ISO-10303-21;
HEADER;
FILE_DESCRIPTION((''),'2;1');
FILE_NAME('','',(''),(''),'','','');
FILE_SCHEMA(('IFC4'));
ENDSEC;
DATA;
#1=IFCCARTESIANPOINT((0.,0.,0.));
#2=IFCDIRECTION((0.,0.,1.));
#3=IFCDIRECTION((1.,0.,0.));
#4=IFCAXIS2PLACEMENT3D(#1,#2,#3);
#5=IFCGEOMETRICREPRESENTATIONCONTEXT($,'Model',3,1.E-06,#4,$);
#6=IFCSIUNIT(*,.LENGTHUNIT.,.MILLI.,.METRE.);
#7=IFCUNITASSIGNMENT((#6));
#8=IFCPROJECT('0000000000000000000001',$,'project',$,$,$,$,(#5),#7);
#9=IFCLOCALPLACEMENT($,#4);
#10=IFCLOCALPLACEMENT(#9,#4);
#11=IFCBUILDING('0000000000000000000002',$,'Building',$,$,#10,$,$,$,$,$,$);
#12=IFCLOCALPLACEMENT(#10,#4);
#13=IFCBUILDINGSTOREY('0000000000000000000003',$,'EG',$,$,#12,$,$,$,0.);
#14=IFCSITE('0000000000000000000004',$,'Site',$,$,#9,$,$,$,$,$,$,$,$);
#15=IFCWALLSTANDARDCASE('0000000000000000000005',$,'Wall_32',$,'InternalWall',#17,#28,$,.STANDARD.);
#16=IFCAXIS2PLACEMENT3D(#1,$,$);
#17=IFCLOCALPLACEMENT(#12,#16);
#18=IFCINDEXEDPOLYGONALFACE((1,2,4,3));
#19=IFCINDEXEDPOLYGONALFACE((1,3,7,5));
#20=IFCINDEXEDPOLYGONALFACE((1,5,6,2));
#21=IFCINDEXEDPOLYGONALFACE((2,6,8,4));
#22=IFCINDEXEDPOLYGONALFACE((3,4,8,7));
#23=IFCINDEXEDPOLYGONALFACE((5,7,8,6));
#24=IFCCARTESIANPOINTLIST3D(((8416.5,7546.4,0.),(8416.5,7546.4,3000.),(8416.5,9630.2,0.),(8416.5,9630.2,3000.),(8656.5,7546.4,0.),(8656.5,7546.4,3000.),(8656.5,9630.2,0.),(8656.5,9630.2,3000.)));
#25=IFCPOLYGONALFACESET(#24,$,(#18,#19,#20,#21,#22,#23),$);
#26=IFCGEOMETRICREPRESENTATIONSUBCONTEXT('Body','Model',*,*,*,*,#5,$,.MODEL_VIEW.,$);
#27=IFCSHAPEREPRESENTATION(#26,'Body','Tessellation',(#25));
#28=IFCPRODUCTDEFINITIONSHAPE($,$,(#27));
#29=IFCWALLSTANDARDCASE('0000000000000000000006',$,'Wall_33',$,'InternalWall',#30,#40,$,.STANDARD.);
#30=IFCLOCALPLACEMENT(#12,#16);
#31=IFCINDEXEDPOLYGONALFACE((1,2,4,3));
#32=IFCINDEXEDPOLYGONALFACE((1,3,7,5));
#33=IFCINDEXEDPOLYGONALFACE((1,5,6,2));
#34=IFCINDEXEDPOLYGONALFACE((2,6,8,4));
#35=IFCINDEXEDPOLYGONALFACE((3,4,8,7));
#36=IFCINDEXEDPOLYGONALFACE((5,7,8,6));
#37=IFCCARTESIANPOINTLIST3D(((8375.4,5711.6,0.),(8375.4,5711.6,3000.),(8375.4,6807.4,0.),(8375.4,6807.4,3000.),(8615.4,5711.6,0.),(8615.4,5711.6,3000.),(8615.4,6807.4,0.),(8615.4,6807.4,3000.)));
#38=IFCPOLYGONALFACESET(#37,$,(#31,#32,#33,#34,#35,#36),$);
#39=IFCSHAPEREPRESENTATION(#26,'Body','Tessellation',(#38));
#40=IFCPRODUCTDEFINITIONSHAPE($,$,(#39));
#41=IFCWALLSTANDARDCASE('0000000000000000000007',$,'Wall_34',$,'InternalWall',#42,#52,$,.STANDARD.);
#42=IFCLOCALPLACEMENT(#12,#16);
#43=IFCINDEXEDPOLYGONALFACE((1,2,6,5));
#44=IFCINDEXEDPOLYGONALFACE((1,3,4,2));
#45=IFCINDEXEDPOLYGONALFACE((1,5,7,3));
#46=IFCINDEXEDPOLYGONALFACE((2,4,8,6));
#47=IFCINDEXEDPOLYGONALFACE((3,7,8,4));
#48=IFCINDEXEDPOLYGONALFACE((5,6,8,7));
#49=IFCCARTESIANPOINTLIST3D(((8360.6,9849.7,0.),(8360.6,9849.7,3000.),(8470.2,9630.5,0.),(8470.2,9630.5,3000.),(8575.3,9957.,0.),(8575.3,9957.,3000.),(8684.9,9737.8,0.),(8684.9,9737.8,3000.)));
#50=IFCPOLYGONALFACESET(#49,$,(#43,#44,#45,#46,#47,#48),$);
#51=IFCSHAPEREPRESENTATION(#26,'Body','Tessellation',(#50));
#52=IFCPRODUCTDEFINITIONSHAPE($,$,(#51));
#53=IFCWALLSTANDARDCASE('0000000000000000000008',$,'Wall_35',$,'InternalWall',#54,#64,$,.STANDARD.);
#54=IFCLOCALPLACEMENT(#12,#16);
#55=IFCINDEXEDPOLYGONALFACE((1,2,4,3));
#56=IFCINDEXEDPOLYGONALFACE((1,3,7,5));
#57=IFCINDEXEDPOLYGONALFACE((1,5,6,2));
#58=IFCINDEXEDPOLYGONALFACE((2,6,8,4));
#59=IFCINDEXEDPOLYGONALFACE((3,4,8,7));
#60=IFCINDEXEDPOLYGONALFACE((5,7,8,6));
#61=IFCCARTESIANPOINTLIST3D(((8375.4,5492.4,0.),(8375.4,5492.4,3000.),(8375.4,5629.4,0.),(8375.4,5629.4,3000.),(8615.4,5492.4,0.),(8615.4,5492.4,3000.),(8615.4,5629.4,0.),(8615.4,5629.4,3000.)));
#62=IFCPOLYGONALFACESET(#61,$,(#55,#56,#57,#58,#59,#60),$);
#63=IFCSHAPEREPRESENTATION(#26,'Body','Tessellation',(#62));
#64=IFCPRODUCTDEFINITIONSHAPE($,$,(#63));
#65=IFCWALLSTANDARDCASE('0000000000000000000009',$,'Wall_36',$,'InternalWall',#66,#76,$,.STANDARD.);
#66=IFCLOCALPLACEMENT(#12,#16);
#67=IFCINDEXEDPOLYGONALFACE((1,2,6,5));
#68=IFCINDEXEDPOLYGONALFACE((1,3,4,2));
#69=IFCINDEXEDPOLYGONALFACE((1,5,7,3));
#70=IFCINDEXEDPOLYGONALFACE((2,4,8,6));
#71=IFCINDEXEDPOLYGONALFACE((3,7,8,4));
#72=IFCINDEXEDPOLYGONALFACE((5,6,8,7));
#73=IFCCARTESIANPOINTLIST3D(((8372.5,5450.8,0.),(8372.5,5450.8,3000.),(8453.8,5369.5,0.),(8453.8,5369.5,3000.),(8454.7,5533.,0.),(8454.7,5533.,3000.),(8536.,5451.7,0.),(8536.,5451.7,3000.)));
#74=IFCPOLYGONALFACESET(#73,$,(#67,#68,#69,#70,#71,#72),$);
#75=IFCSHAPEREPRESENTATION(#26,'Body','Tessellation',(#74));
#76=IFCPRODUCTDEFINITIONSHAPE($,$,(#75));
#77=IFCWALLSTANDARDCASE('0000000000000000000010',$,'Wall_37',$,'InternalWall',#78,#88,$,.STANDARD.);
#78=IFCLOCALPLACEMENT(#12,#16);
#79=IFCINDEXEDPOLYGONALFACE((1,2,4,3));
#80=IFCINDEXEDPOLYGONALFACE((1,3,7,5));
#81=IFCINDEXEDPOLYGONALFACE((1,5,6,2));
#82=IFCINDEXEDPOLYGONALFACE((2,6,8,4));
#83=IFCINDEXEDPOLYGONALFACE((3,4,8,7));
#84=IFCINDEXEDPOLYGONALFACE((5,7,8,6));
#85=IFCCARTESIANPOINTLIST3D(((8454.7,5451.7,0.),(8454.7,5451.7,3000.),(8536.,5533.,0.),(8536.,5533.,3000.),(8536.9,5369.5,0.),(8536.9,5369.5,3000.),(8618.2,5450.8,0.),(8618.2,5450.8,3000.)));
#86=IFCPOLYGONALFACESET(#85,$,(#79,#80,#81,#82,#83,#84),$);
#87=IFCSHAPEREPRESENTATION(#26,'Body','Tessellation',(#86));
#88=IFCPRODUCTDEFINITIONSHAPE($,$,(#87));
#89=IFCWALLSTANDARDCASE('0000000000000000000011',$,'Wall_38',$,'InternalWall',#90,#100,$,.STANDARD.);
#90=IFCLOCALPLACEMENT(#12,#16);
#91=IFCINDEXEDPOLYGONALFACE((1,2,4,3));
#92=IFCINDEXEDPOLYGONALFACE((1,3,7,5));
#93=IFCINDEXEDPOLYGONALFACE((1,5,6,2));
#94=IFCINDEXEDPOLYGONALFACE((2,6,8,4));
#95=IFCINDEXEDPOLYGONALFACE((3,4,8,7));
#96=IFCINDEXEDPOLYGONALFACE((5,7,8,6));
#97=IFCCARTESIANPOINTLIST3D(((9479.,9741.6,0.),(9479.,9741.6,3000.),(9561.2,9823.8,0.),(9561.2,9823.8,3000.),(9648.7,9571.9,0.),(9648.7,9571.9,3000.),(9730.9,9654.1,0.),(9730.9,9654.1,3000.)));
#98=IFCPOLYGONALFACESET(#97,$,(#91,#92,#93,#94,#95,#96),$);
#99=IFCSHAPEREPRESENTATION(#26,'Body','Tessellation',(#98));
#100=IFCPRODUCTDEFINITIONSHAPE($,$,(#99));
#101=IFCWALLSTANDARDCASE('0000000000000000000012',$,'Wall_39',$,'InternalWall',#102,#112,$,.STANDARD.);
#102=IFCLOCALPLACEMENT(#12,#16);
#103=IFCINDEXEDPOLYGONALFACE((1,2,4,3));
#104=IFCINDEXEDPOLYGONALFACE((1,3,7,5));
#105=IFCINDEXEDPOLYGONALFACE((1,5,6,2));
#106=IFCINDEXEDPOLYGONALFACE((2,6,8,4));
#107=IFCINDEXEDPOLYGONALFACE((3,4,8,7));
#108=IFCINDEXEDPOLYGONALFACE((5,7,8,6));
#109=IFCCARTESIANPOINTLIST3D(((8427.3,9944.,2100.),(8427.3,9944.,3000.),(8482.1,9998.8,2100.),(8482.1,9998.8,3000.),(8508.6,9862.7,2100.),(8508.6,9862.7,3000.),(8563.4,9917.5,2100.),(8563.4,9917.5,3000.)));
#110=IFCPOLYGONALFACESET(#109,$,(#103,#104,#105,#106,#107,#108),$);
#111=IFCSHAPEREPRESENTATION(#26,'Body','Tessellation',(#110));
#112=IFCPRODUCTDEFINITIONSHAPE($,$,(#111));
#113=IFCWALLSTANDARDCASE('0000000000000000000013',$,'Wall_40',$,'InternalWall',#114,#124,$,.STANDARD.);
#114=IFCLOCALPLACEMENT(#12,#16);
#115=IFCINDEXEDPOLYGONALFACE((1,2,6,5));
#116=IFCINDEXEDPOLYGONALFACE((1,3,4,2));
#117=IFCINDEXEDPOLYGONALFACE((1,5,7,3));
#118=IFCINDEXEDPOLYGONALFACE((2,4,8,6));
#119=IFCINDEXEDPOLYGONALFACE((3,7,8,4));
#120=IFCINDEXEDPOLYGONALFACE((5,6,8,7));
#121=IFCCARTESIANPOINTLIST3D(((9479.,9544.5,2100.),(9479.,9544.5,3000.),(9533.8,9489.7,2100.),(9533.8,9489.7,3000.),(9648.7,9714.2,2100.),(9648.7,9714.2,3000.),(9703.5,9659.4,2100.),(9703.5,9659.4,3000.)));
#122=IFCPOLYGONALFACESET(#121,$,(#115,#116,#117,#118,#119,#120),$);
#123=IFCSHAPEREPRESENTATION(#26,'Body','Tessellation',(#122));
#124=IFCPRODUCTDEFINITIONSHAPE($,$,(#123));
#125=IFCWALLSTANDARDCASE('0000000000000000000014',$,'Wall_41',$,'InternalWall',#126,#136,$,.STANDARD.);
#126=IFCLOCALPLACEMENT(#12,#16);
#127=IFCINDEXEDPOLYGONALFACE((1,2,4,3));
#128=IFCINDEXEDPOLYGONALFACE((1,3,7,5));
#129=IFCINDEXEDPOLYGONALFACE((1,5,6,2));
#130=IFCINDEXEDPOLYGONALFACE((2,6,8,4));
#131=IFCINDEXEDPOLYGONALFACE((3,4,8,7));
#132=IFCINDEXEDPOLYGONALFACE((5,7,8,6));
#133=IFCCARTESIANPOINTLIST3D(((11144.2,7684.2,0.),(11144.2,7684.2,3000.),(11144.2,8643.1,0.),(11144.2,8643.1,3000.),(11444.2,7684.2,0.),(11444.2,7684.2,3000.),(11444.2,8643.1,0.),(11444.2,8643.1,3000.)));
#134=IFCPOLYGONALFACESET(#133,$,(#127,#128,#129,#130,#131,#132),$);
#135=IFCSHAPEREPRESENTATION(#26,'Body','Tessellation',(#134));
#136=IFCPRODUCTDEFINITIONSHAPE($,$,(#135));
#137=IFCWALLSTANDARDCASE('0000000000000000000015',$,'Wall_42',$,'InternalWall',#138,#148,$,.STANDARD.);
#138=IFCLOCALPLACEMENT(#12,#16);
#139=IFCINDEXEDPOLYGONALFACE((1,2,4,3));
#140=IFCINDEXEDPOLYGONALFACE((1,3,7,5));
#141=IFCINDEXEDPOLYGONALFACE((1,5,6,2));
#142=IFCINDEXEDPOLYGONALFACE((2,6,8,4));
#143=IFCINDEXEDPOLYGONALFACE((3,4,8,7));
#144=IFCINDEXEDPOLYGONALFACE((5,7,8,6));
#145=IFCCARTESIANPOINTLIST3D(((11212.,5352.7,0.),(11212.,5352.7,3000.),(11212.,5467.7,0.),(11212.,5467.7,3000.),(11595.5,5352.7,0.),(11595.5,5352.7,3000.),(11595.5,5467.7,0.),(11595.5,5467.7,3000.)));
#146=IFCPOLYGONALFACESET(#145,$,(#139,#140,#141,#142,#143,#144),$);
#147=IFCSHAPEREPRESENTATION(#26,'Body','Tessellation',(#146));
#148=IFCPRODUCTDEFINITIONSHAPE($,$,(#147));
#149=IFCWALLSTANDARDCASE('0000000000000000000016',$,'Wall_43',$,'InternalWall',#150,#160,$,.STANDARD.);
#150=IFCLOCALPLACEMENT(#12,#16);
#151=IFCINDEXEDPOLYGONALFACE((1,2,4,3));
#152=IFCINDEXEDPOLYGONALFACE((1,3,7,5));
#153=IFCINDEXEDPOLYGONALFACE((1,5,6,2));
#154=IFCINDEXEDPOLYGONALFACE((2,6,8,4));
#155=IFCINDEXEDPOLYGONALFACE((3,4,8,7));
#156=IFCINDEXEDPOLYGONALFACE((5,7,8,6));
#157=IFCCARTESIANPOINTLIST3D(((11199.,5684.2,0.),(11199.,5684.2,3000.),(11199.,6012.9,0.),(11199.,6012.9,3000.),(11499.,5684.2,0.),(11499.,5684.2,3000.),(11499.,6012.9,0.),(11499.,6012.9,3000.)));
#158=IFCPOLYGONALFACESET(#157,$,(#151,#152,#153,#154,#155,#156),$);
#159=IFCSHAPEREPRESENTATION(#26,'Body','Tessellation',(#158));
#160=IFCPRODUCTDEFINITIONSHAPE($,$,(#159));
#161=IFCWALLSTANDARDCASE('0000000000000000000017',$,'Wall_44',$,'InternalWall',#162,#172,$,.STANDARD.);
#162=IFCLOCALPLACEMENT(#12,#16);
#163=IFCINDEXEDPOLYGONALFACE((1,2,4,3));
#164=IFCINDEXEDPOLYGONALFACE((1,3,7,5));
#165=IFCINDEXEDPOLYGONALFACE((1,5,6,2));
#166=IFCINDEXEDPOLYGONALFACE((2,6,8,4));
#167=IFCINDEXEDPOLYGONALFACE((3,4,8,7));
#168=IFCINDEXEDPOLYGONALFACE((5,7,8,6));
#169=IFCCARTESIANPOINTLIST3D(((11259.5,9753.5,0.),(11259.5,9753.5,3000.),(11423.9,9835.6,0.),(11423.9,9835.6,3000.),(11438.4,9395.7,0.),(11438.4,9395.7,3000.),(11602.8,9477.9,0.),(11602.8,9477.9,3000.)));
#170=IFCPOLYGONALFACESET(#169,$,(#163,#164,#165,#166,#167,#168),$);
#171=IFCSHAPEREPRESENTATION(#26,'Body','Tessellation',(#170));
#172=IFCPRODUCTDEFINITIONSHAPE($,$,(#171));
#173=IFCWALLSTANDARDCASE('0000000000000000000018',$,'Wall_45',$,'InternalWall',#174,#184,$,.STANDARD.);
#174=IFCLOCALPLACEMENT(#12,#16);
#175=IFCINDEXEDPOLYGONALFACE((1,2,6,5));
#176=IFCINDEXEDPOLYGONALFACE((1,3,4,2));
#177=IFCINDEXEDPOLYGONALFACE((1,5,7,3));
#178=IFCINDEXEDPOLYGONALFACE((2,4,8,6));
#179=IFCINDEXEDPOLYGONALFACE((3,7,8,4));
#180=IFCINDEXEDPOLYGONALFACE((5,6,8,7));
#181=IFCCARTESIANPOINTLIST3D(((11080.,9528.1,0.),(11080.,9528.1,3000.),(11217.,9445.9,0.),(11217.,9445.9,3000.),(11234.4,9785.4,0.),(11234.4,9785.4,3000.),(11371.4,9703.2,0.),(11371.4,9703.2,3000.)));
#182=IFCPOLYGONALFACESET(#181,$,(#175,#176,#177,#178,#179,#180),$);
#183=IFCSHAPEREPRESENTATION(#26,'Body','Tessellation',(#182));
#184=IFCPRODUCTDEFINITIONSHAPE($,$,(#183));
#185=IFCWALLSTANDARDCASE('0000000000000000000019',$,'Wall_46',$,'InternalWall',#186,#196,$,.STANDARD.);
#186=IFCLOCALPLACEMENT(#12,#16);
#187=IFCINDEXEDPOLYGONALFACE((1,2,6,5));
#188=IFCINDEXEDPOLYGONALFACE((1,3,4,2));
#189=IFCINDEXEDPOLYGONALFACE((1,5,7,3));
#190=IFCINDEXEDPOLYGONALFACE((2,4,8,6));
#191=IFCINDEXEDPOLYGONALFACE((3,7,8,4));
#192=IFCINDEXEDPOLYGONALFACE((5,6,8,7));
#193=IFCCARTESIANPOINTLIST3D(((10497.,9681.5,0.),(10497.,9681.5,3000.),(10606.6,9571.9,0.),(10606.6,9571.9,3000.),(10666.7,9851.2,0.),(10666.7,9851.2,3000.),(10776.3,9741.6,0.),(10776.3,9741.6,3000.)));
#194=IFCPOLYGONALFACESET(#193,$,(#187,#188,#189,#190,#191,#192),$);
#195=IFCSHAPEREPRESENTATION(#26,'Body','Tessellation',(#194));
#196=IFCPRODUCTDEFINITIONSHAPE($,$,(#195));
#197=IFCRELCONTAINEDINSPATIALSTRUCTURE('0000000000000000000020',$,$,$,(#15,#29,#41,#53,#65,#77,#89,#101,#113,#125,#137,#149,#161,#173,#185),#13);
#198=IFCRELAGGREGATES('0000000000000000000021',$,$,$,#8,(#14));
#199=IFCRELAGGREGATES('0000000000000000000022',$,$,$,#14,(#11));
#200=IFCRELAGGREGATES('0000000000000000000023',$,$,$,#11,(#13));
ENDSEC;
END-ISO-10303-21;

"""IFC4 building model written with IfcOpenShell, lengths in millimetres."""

from ifc_helpers import new_model, si_unit, frame, origin_with_axes, place, context, subcontext, project, spatial, rectangle, extrude, element, save


model = new_model("IFC4")

# Units and contexts
model_context = context("Model", 3, precision=1e-06, world=origin_with_axes())
body_context = subcontext(model_context, "Body", "Model", "MODEL_VIEW")
ifc_project = project(units=[si_unit("LENGTHUNIT", "METRE", prefix="MILLI")], contexts=[model_context])

# Site, building, storey
site_placement = place(None, origin_with_axes())
site = spatial("IfcSite", under=ifc_project, at=site_placement, Name="Site")
building_placement = place(site_placement, origin_with_axes())
building = spatial("IfcBuilding", under=site, at=building_placement, Name="Building")
storey_placement = place(building_placement, origin_with_axes())
storey = spatial("IfcBuildingStorey", under=building, at=storey_placement, Name="EG", Elevation=0.0)

# Walls
wall_1_placement = place(storey_placement, origin_with_axes())
element("IfcWallStandardCase", 1, at=wall_1_placement, inside=storey, Name="Wall_32", ObjectType="InternalWall", PredefinedType="STANDARD", context=body_context, shape_type="SweptSolid", body=[
    extrude(rectangle(XDim=2083.8, YDim=240.0), frame((8536.5, 8588.3, 0.0), z_axis=(0.0, 0.0, 1.0), x_axis=(0.0, 1.0, 0.0)), (0.0, 0.0, 1.0), 3000.0),
])
wall_2_placement = place(storey_placement, origin_with_axes())
element("IfcWallStandardCase", 2, at=wall_2_placement, inside=storey, Name="Wall_33", ObjectType="InternalWall", PredefinedType="STANDARD", context=body_context, shape_type="SweptSolid", body=[
    extrude(rectangle(XDim=1095.9, YDim=240.0), frame((8495.4, 6259.5, 0.0), z_axis=(0.0, 0.0, 1.0), x_axis=(0.0, -1.0, 0.0)), (0.0, 0.0, 1.0), 3000.0),
])
wall_3_placement = place(storey_placement, origin_with_axes())
element("IfcWallStandardCase", 3, at=wall_3_placement, inside=storey, Name="Wall_34", ObjectType="InternalWall", PredefinedType="STANDARD", context=body_context, shape_type="SweptSolid", body=[
    extrude(rectangle(XDim=245.0, YDim=240.0), frame((8522.8, 9793.8, 0.0), z_axis=(0.0, 0.0, 1.0), x_axis=(-0.447214, 0.894427, 0.0)), (0.0, 0.0, 1.0), 3000.0),
])
wall_4_placement = place(storey_placement, origin_with_axes())
element("IfcWallStandardCase", 4, at=wall_4_placement, inside=storey, Name="Wall_35", ObjectType="InternalWall", PredefinedType="STANDARD", context=body_context, shape_type="SweptSolid", body=[
    extrude(rectangle(XDim=137.0, YDim=240.0), frame((8495.4, 5560.9, 0.0), z_axis=(0.0, 0.0, 1.0), x_axis=(0.0, -1.0, 0.0)), (0.0, 0.0, 1.0), 3000.0),
])
wall_5_placement = place(storey_placement, origin_with_axes())
element("IfcWallStandardCase", 5, at=wall_5_placement, inside=storey, Name="Wall_36", ObjectType="InternalWall", PredefinedType="STANDARD", context=body_context, shape_type="SweptSolid", body=[
    extrude(rectangle(XDim=116.2, YDim=115.0), frame((8454.3, 5451.3, 0.0), z_axis=(0.0, 0.0, 1.0), x_axis=(-0.707107, -0.707107, 0.0)), (0.0, 0.0, 1.0), 3000.0),
])
wall_6_placement = place(storey_placement, origin_with_axes())
element("IfcWallStandardCase", 6, at=wall_6_placement, inside=storey, Name="Wall_37", ObjectType="InternalWall", PredefinedType="STANDARD", context=body_context, shape_type="SweptSolid", body=[
    extrude(rectangle(XDim=116.2, YDim=115.0), frame((8536.5, 5451.3, 0.0), z_axis=(0.0, 0.0, 1.0), x_axis=(0.707107, -0.707107, 0.0)), (0.0, 0.0, 1.0), 3000.0),
])
wall_7_placement = place(storey_placement, origin_with_axes())
element("IfcWallStandardCase", 7, at=wall_7_placement, inside=storey, Name="Wall_38", ObjectType="InternalWall", PredefinedType="STANDARD", context=body_context, shape_type="SweptSolid", body=[
    extrude(rectangle(XDim=116.2, YDim=240.0), frame((9605.0, 9697.9, 0.0), z_axis=(0.0, 0.0, 1.0), x_axis=(0.707107, 0.707107, 0.0)), (0.0, 0.0, 1.0), 3000.0),
])

# Walls, openings
wall_8_placement = place(storey_placement, origin_with_axes())
wall_8 = element("IfcWallStandardCase", 8, at=wall_8_placement, inside=storey, Name="Wall_39", ObjectType="InternalWall", PredefinedType="STANDARD", context=body_context, shape_type="SweptSolid", body=[
    extrude(rectangle(XDim=77.5, YDim=115.0), frame((8495.4, 9930.7, 0.0), z_axis=(0.0, 0.0, 1.0), x_axis=(0.707107, 0.707107, 0.0)), (0.0, 0.0, 1.0), 3000.0),
])
opening_1_placement = place(wall_8_placement, origin_with_axes())
element("IfcOpeningElement", 9, at=opening_1_placement, inside=storey, cuts=wall_8, context=body_context, shape_type="SweptSolid", body=[
    extrude(rectangle(XDim=1089.4, YDim=115.0), frame((8663.4, 10098.8, 0.0), z_axis=(0.0, 0.0, 1.0), x_axis=(0.707107, 0.707107, 0.0)), (0.0, 0.0, 1.0), 2100.0),
])
wall_9_placement = place(storey_placement, origin_with_axes())
wall_9 = element("IfcWallStandardCase", 10, at=wall_9_placement, inside=storey, Name="Wall_40", ObjectType="InternalWall", PredefinedType="STANDARD", context=body_context, shape_type="SweptSolid", body=[
    extrude(rectangle(XDim=77.5, YDim=240.0), frame((9591.3, 9602.0, 0.0), z_axis=(0.0, 0.0, 1.0), x_axis=(0.707107, -0.707107, 0.0)), (0.0, 0.0, 1.0), 3000.0),
])
opening_2_placement = place(wall_9_placement, origin_with_axes())
element("IfcOpeningElement", 11, at=opening_2_placement, inside=storey, cuts=wall_9, context=body_context, shape_type="SweptSolid", body=[
    extrude(rectangle(XDim=1329.5, YDim=240.0), frame((10014.4, 9178.8, 0.0), z_axis=(0.0, 0.0, 1.0), x_axis=(0.707107, -0.707107, 0.0)), (0.0, 0.0, 1.0), 2100.0),
])

# Walls
wall_10_placement = place(storey_placement, origin_with_axes())
element("IfcWallStandardCase", 12, at=wall_10_placement, inside=storey, Name="Wall_41", ObjectType="InternalWall", PredefinedType="STANDARD", context=body_context, shape_type="SweptSolid", body=[
    extrude(rectangle(XDim=958.9, YDim=300.0), frame((11294.2, 8163.6, 0.0), z_axis=(0.0, 0.0, 1.0), x_axis=(0.0, 1.0, 0.0)), (0.0, 0.0, 1.0), 3000.0),
])
wall_11_placement = place(storey_placement, origin_with_axes())
element("IfcWallStandardCase", 13, at=wall_11_placement, inside=storey, Name="Wall_42", ObjectType="InternalWall", PredefinedType="STANDARD", context=body_context, shape_type="SweptSolid", body=[
    extrude(rectangle(XDim=383.6, YDim=115.0), frame((11403.8, 5410.2, 0.0), z_axis=(0.0, 0.0, 1.0), x_axis=(1.0, 0.0, 0.0)), (0.0, 0.0, 1.0), 3000.0),
])
wall_12_placement = place(storey_placement, origin_with_axes())
element("IfcWallStandardCase", 14, at=wall_12_placement, inside=storey, Name="Wall_43", ObjectType="InternalWall", PredefinedType="STANDARD", context=body_context, shape_type="SweptSolid", body=[
    extrude(rectangle(XDim=328.8, YDim=300.0), frame((11349.0, 5848.5, 0.0), z_axis=(0.0, 0.0, 1.0), x_axis=(0.0, -1.0, 0.0)), (0.0, 0.0, 1.0), 3000.0),
])
wall_13_placement = place(storey_placement, origin_with_axes())
element("IfcWallStandardCase", 15, at=wall_13_placement, inside=storey, Name="Wall_44", ObjectType="InternalWall", PredefinedType="STANDARD", context=body_context, shape_type="SweptSolid", body=[
    extrude(rectangle(XDim=183.8, YDim=400.0), frame((11431.2, 9615.7, 0.0), z_axis=(0.0, 0.0, 1.0), x_axis=(0.894427, 0.447214, 0.0)), (0.0, 0.0, 1.0), 3000.0),
])
wall_14_placement = place(storey_placement, origin_with_axes())
element("IfcWallStandardCase", 16, at=wall_14_placement, inside=storey, Name="Wall_45", ObjectType="InternalWall", PredefinedType="STANDARD", context=body_context, shape_type="SweptSolid", body=[
    extrude(rectangle(XDim=159.8, YDim=300.0), frame((11225.7, 9615.7, 0.0), z_axis=(0.0, 0.0, 1.0), x_axis=(0.857493, -0.514496, 0.0)), (0.0, 0.0, 1.0), 3000.0),
])
wall_15_placement = place(storey_placement, origin_with_axes())
element("IfcWallStandardCase", 17, at=wall_15_placement, inside=storey, Name="Wall_46", ObjectType="InternalWall", PredefinedType="STANDARD", context=body_context, shape_type="SweptSolid", body=[
    extrude(rectangle(XDim=155.0, YDim=240.0), frame((10636.6, 9711.6, 0.0), z_axis=(0.0, 0.0, 1.0), x_axis=(-0.707107, 0.707107, 0.0)), (0.0, 0.0, 1.0), 3000.0),
])

save(model, "model.ifc")
